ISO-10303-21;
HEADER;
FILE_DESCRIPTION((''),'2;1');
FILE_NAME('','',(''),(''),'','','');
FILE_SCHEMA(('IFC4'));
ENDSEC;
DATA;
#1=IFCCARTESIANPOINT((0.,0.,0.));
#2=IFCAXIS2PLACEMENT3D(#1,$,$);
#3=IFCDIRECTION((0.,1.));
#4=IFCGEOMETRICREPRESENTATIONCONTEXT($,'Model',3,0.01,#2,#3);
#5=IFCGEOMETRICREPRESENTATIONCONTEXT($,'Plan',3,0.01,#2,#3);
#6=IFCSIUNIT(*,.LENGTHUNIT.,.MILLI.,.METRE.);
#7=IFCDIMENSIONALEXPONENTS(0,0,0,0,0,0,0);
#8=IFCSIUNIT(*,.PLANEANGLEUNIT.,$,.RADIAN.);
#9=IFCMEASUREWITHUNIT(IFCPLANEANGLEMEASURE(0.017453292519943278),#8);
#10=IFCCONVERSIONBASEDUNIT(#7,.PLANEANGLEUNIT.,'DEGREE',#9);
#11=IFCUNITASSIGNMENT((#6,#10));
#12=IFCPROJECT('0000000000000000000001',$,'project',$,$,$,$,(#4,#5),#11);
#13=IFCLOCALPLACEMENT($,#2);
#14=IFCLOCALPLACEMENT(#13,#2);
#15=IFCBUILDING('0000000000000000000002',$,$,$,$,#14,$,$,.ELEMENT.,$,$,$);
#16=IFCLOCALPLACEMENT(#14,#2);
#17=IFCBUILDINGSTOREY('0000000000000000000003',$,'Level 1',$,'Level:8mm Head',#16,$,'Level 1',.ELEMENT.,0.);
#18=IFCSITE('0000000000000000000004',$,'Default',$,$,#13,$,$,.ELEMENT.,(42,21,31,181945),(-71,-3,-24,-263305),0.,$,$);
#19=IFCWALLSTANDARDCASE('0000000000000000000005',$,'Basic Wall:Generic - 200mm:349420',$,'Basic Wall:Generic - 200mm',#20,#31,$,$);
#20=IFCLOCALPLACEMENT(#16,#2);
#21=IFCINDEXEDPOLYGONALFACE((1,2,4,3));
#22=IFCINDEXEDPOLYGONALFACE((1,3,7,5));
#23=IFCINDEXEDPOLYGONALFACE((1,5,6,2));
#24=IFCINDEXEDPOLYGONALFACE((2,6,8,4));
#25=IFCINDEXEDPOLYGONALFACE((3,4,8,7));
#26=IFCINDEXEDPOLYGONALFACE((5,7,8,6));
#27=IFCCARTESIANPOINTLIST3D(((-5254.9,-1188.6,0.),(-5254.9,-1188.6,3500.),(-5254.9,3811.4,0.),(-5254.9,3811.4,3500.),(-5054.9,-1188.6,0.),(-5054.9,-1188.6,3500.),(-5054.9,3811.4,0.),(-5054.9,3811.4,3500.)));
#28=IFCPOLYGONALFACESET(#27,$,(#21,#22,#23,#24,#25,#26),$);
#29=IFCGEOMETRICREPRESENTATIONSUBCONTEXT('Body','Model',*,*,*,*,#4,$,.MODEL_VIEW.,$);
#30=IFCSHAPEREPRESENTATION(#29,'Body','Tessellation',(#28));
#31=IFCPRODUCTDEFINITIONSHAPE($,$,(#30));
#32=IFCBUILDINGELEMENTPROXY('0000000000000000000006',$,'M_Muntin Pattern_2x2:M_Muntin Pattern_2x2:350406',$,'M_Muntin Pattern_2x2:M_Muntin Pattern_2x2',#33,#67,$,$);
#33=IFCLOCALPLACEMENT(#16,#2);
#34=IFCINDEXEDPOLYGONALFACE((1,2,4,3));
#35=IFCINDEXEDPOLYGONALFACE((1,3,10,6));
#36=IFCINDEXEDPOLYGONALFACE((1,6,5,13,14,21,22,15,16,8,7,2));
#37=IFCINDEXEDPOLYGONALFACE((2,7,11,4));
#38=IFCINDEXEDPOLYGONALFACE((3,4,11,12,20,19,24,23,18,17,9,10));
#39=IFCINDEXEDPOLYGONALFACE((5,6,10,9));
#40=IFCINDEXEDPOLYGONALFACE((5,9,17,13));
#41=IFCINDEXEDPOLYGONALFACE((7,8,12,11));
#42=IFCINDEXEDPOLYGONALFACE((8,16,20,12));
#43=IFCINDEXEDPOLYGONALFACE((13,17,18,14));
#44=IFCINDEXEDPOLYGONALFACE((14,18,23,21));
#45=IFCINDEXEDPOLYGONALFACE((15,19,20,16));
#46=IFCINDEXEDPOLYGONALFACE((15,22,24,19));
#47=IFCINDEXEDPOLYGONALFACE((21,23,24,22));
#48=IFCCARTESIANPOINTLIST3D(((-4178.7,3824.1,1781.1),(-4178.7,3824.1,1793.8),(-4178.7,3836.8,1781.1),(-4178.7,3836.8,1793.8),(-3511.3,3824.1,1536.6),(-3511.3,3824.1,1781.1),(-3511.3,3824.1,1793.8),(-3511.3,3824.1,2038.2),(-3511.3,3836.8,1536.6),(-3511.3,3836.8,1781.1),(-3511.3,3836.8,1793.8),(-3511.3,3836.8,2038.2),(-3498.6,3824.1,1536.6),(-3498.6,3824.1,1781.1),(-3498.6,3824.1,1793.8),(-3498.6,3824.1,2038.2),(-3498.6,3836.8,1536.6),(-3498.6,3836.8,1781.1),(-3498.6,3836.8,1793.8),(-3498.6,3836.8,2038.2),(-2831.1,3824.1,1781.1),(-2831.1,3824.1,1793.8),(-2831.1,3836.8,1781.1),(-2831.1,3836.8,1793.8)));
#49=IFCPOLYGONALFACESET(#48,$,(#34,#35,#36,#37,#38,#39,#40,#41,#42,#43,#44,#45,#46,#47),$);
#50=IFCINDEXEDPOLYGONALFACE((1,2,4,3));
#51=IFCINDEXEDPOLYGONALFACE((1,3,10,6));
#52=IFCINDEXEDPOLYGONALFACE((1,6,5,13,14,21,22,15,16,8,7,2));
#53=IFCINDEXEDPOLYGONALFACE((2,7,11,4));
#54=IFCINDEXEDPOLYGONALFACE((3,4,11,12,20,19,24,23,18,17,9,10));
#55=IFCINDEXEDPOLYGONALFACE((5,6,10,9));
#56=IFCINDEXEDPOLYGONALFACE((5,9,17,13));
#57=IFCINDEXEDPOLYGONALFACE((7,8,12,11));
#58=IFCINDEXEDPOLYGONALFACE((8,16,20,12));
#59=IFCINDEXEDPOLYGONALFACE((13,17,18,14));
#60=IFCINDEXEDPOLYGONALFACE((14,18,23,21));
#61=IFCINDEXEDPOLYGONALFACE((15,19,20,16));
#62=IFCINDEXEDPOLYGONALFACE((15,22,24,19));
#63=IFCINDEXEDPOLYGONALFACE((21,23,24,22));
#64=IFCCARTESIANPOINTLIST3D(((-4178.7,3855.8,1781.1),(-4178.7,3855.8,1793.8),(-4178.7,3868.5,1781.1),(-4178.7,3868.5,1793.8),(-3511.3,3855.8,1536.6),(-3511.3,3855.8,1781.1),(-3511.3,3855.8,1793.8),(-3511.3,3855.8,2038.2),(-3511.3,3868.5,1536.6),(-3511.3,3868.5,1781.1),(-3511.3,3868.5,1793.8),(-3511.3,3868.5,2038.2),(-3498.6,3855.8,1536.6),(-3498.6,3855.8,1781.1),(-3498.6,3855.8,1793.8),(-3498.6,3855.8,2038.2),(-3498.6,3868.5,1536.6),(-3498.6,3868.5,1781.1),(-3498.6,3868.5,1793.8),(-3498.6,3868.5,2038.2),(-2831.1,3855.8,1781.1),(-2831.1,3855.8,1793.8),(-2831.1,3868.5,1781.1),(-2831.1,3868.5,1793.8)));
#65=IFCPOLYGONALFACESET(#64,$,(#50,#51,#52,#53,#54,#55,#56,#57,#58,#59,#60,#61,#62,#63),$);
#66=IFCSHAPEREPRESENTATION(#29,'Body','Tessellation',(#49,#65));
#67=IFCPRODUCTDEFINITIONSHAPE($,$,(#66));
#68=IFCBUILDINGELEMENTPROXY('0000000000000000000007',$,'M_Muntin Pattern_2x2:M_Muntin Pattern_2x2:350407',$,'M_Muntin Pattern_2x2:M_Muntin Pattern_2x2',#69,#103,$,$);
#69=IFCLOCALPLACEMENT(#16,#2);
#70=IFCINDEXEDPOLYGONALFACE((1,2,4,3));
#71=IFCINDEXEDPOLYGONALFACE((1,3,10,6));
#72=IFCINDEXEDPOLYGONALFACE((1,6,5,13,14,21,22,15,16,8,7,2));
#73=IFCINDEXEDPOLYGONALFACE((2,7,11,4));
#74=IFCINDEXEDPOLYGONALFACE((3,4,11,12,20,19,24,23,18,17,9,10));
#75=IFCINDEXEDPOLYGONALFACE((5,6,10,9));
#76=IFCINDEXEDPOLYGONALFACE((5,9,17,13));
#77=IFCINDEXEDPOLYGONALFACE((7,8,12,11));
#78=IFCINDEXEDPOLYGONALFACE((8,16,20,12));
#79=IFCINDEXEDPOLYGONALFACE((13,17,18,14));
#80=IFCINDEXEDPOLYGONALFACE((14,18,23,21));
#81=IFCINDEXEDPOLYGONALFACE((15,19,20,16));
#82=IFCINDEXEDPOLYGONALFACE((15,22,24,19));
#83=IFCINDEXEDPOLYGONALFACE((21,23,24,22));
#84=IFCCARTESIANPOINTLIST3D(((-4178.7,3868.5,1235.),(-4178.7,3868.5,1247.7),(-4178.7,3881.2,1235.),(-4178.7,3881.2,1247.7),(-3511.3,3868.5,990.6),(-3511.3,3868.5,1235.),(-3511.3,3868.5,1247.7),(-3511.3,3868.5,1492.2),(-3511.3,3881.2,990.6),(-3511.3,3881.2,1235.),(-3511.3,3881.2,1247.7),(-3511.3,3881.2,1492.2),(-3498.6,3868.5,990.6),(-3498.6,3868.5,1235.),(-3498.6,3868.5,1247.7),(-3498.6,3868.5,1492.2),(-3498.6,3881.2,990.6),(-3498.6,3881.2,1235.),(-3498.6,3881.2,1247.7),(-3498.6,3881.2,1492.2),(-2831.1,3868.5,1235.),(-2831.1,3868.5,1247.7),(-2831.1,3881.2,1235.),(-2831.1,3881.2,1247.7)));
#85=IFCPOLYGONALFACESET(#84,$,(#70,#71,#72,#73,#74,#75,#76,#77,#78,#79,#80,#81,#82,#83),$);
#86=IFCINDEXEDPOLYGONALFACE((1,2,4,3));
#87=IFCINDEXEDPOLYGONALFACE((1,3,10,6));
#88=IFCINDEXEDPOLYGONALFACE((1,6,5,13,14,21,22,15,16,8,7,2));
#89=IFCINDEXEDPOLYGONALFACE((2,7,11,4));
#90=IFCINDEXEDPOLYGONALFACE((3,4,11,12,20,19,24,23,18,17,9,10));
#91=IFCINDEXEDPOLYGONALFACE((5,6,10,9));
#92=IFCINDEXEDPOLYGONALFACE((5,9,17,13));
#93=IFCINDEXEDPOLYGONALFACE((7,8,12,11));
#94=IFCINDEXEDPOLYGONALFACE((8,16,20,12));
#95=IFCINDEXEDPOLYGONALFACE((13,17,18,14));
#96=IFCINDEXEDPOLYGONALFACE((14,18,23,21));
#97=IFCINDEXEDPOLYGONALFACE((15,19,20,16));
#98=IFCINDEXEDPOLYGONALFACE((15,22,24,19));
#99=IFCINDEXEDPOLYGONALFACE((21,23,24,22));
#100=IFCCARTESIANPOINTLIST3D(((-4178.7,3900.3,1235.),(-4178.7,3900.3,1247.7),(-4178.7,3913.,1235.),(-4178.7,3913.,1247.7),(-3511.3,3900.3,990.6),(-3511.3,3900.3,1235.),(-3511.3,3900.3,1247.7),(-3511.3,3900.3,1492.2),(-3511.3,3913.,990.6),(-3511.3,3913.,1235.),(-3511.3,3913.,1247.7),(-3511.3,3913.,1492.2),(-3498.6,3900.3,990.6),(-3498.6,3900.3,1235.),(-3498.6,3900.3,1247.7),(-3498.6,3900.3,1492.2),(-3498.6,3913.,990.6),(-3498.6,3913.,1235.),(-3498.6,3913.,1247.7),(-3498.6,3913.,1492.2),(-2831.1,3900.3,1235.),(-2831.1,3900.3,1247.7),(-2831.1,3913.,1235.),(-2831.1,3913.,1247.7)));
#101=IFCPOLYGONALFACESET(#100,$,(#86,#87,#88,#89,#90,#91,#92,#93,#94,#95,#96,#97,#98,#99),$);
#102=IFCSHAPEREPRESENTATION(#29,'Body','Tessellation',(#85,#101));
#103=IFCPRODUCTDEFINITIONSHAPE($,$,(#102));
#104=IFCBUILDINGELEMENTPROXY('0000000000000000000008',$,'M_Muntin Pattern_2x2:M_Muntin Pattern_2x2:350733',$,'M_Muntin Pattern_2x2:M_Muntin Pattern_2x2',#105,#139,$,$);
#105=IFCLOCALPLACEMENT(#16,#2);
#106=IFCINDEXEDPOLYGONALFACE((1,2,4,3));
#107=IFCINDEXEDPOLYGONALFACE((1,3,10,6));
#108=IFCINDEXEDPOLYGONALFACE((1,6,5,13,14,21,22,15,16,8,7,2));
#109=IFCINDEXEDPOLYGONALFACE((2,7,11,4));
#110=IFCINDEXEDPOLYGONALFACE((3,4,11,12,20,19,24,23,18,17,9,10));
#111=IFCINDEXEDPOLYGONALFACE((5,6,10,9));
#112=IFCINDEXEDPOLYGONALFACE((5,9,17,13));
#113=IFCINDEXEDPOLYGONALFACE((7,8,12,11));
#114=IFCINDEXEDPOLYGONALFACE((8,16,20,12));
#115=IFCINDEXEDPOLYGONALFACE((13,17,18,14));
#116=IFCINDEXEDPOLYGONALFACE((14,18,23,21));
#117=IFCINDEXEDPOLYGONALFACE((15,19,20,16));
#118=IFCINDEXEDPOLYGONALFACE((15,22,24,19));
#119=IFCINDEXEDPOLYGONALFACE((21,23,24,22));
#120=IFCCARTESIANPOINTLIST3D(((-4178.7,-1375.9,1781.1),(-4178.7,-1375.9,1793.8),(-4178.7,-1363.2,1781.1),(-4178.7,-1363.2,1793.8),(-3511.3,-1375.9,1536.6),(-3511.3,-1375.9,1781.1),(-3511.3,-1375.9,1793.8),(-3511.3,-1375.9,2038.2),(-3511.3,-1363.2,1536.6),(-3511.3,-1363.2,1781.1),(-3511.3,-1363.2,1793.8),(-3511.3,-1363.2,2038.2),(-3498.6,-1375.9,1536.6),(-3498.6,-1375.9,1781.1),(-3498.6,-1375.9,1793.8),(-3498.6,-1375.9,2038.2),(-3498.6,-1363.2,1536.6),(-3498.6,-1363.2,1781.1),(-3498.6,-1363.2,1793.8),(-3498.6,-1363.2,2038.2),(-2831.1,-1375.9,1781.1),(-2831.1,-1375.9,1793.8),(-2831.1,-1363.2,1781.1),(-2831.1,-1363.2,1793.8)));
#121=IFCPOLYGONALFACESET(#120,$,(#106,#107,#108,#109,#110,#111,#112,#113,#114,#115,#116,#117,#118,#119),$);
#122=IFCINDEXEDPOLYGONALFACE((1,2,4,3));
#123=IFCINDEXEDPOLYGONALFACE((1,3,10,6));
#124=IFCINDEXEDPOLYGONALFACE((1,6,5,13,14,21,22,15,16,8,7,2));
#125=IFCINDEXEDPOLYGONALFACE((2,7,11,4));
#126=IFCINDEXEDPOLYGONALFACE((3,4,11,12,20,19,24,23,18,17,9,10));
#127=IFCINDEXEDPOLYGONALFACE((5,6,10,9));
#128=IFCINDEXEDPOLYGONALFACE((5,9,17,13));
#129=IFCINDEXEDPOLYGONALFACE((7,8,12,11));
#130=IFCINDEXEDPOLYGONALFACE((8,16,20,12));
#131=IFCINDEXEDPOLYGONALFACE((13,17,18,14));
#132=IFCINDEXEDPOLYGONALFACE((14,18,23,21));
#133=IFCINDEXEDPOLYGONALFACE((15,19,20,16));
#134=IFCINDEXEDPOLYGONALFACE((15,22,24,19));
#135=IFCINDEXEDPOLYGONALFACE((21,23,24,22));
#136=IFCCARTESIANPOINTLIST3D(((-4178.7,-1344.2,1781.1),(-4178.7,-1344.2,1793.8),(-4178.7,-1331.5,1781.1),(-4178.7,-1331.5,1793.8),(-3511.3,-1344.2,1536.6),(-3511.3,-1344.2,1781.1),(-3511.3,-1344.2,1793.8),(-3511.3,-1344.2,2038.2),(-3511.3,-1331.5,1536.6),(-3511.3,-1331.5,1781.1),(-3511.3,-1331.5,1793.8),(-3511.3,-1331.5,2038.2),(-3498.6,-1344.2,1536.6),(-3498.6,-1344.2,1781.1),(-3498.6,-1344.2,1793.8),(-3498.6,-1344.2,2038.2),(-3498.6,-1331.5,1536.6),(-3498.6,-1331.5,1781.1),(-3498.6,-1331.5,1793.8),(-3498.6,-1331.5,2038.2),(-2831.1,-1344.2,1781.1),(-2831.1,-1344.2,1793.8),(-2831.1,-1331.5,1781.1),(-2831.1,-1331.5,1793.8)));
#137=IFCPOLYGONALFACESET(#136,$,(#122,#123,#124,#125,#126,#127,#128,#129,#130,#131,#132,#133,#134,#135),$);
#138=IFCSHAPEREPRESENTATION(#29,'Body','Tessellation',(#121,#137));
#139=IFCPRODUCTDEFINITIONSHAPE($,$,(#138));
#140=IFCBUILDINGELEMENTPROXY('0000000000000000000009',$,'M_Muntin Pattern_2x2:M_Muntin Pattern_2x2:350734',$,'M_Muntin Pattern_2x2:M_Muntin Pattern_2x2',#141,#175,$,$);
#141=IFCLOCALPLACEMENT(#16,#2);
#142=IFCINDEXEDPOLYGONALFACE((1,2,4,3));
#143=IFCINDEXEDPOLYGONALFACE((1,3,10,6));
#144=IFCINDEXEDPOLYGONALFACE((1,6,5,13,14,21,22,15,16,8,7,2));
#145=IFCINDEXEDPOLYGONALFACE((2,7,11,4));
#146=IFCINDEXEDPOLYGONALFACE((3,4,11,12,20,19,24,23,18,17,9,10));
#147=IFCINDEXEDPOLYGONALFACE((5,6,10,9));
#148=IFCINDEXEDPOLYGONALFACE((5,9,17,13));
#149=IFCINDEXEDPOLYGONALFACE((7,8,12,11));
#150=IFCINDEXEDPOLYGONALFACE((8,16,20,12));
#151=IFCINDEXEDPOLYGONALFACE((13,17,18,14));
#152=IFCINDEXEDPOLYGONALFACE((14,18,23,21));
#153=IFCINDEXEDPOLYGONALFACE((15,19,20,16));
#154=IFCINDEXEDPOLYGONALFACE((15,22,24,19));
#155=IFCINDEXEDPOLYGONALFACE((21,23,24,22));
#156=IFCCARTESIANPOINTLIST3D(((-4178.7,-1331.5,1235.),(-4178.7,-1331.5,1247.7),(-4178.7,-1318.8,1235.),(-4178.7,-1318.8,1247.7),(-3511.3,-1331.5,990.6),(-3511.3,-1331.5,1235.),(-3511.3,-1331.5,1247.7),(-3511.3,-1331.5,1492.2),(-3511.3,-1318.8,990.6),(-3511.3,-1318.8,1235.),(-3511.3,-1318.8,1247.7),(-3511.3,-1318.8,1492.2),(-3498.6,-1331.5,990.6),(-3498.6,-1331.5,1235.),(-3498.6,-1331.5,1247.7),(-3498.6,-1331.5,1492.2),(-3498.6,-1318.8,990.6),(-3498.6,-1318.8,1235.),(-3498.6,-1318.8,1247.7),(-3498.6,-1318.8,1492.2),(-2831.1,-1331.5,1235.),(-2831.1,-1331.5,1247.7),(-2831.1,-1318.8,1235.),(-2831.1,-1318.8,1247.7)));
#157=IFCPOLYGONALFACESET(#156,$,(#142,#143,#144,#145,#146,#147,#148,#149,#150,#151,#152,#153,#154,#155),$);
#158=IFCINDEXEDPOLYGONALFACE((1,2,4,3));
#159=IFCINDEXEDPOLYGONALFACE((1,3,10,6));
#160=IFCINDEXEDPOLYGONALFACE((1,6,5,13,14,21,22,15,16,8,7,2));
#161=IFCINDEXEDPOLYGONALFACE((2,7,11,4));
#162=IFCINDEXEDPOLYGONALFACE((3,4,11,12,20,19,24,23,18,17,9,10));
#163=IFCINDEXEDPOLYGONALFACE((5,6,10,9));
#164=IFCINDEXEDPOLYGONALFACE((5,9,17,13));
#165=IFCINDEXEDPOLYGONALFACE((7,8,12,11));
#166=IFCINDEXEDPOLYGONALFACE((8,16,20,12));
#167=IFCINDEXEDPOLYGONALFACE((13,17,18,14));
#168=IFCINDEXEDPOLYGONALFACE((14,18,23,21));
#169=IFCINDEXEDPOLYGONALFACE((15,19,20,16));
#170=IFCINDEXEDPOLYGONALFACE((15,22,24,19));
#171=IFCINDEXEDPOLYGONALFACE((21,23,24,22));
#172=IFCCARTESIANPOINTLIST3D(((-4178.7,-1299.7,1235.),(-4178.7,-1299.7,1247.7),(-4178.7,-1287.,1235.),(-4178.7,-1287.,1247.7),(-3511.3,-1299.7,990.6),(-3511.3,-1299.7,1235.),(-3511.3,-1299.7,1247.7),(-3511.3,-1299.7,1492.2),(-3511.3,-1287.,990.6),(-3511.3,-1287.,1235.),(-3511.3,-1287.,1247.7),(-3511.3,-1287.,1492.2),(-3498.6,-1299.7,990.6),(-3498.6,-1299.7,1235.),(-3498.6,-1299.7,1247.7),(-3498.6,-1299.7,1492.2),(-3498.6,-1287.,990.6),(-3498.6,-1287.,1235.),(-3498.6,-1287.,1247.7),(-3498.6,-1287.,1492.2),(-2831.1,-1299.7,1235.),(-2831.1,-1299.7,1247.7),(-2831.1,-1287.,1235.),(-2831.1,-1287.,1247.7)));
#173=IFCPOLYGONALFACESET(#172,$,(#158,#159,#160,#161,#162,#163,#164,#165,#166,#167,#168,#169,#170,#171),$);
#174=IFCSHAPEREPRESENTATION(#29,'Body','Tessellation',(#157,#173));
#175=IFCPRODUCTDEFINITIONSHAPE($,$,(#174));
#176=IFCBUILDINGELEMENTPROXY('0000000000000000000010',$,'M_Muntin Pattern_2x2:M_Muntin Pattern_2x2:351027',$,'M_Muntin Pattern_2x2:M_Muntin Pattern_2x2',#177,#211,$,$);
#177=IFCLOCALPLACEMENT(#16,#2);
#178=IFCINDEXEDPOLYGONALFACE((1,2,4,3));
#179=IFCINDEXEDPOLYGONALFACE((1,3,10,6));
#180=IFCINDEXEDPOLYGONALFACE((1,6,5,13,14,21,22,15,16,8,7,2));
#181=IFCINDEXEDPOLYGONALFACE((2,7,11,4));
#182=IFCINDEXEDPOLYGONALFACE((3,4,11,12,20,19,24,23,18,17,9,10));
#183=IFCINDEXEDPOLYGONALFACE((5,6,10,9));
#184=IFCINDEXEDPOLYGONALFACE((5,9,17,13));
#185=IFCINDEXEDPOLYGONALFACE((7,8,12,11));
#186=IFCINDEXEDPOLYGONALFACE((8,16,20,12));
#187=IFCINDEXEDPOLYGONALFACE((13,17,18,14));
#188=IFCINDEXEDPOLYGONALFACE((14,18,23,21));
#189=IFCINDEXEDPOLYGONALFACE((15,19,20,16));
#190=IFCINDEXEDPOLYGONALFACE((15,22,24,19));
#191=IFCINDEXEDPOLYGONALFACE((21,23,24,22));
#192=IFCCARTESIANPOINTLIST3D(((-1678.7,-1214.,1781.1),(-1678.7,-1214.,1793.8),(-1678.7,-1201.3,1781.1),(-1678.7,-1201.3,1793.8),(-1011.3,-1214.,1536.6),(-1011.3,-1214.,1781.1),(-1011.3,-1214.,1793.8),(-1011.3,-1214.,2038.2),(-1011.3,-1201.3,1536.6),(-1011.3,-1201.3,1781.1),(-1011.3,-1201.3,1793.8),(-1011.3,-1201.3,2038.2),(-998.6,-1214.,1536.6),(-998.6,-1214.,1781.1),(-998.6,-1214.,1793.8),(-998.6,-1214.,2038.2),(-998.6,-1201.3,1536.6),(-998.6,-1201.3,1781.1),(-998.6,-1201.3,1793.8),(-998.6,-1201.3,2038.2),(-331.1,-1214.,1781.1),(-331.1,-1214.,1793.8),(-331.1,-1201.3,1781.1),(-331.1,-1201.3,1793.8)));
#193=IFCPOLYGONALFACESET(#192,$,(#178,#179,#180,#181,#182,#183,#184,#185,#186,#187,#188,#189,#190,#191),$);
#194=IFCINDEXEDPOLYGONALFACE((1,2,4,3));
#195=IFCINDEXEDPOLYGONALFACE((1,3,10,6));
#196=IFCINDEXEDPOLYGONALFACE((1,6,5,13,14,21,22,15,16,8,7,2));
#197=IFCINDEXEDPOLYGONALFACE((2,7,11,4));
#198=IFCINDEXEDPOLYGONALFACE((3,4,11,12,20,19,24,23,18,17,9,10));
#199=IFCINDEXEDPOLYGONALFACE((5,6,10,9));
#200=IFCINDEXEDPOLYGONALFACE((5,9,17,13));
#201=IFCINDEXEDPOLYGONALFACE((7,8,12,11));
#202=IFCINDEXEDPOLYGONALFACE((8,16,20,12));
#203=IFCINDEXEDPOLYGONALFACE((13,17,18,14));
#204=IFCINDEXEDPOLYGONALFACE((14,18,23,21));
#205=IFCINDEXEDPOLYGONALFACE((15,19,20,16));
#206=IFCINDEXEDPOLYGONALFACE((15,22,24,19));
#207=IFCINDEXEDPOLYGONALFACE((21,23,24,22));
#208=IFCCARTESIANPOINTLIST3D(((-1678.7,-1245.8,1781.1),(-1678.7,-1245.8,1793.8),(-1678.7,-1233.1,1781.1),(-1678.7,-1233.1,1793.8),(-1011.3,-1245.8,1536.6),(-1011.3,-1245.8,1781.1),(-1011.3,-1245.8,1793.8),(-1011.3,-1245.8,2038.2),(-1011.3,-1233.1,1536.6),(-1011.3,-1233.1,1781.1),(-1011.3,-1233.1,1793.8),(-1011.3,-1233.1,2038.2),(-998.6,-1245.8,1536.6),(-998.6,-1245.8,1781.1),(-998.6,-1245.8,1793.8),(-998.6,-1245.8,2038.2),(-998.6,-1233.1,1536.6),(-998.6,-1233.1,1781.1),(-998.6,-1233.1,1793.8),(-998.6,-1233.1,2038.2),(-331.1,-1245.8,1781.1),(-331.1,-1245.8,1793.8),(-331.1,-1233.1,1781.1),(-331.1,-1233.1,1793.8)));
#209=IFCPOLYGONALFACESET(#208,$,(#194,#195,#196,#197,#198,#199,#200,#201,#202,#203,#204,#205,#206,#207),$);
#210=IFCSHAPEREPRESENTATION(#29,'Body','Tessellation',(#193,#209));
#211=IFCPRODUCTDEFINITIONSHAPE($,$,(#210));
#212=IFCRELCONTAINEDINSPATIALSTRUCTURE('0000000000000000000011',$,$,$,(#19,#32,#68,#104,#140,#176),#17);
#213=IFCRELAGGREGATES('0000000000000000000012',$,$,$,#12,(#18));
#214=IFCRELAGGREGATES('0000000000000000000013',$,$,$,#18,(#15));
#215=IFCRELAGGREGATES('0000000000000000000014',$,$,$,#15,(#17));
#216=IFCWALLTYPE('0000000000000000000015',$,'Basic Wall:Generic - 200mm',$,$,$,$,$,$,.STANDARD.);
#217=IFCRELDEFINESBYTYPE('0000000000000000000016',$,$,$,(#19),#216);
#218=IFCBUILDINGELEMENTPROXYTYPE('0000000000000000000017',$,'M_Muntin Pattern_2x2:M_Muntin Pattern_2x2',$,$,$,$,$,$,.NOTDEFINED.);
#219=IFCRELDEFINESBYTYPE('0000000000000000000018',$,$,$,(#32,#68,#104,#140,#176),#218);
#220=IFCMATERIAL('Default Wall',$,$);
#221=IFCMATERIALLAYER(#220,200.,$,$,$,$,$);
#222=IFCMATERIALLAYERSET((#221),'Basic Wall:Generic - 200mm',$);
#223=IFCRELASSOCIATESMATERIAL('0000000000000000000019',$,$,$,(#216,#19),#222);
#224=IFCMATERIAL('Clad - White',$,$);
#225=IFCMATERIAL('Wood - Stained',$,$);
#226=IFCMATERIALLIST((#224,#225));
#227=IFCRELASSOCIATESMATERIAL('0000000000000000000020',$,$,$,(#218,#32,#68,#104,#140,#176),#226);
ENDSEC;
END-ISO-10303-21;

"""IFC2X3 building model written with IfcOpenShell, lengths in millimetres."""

from ifc_helpers import new_model, entity, si_unit, converted_unit, direction, frame, frame_2d, origin, place, context, subcontext, project, spatial, polyline, rectangle, outline, extrude, source, transform, mapped, material, material_list, layer, layer_set, layer_usage, type_object, type_shapes, element, save


model = new_model("IFC2X3")

# Units and contexts
model_context = context("Model", 3, precision=0.01, world=origin(), true_north=direction((0.0, 1.0)))
plan_context = context("Plan", 3, precision=0.01, world=origin(), true_north=direction((0.0, 1.0)))
body_context = subcontext(model_context, "Body", "Model", "MODEL_VIEW")
ifc_project = project(units=[si_unit("LENGTHUNIT", "METRE", prefix="MILLI"), converted_unit("PLANEANGLEUNIT", "DEGREE", entity("IfcPlaneAngleMeasure", 0.017453292519943278), si_unit("PLANEANGLEUNIT", "RADIAN"), dimensions=[0, 0, 0, 0, 0, 0, 0])], contexts=[model_context, plan_context])

# Site, building, storey
site_placement = place(None, origin())
site = spatial("IfcSite", under=ifc_project, at=site_placement, Name="Default", CompositionType="ELEMENT", RefLatitude=(42, 21, 31, 181945), RefLongitude=(-71, -3, -24, -263305), RefElevation=0.0)
building_placement = place(site_placement, origin())
building = spatial("IfcBuilding", under=site, at=building_placement, CompositionType="ELEMENT")
storey_placement = place(building_placement, origin())
storey = spatial("IfcBuildingStorey", under=building, at=storey_placement, Name="Level 1", ObjectType="Level:8mm Head", LongName="Level 1", CompositionType="ELEMENT", Elevation=0.0)

# Shared definitions
ifc_material_1 = material(Name="Default Wall")
ifc_layer = layer(ifc_material_1, 200.0)
ifc_layer_set = layer_set([ifc_layer], Name="Basic Wall:Generic - 200mm")
wall_type = type_object("IfcWallType", Name="Basic Wall:Generic - 200mm", PredefinedType="STANDARD", material=ifc_layer_set)
ifc_material_2 = material(Name="Wood - Stained")

# Wall
ifc_layer_usage_1 = layer_usage(ifc_layer_set, "AXIS2", "NEGATIVE", 100.0)
wall_1_placement = place(storey_placement, frame((-5154.9, -1188.6, 0.0), z_axis=(0.0, 0.0, 1.0), x_axis=(0.0, 1.0, 0.0)))
element("IfcWallStandardCase", 1, at=wall_1_placement, inside=storey, type_object=wall_type, material=ifc_layer_usage_1, Name="Basic Wall:Generic - 200mm:349420", ObjectType="Basic Wall:Generic - 200mm", context=body_context, shape_type="SweptSolid", body=[
    extrude(rectangle(XDim=5000.0, YDim=200.0, at=frame_2d((2500.0, 0.0), x_axis=(-1.0, 0.0))), origin(), (0.0, 0.0, 1.0), 3500.0),
])

# Building element proxies
ifc_material_3 = material(Name="Clad - White")
ifc_material_list_1 = material_list([ifc_material_3, ifc_material_2])
building_element_proxy_type_1 = type_object("IfcBuildingElementProxyType", Name="M_Muntin Pattern_2x2:M_Muntin Pattern_2x2", PredefinedType="NOTDEFINED", material=ifc_material_list_1)
shared_shape_1 = source(origin(), body_context, "Body", "SweptSolid", [
    extrude(outline(polyline([(6.4, -6.4), (250.8, -6.4), (250.8, 6.3), (6.4, 6.3), (6.4, 673.8), (-6.3, 673.8), (-6.3, 6.3), (-250.8, 6.3), (-250.8, -6.4), (-6.3, -6.4), (-6.3, -673.8), (6.4, -673.8), (6.4, -6.4)])), frame((0.0, 9.5, 250.8), z_axis=(0.0, 1.0, 0.0), x_axis=(0.0, 0.0, 1.0)), (0.0, 0.0, 1.0), 12.7),
    extrude(outline(polyline([(6.4, -6.4), (250.8, -6.4), (250.8, 6.3), (6.4, 6.3), (6.4, 673.8), (-6.3, 673.8), (-6.3, 6.3), (-250.8, 6.3), (-250.8, -6.4), (-6.3, -6.4), (-6.3, -673.8), (6.4, -673.8), (6.4, -6.4)])), frame((0.0, -22.2, 250.8), z_axis=(0.0, 1.0, 0.0), x_axis=(0.0, 0.0, 1.0)), (0.0, 0.0, 1.0), 12.7),
])
type_shapes(building_element_proxy_type_1, [shared_shape_1])
for number, where, z_axis, x_axis, name in (
    (2, (-3504.9, 3846.3, 1536.6), (0.0, 0.0, 1.0), (-1.0, 0.0, 0.0), "M_Muntin Pattern_2x2:M_Muntin Pattern_2x2:350406"),
    (3, (-3504.9, 3890.7, 990.6), (0.0, 0.0, 1.0), (-1.0, 0.0, 0.0), "M_Muntin Pattern_2x2:M_Muntin Pattern_2x2:350407"),
    (4, (-3504.9, -1353.7, 1536.6), (0.0, 0.0, 1.0), (-1.0, 0.0, 0.0), "M_Muntin Pattern_2x2:M_Muntin Pattern_2x2:350733"),
    (5, (-3504.9, -1309.3, 990.6), (0.0, 0.0, 1.0), (-1.0, 0.0, 0.0), "M_Muntin Pattern_2x2:M_Muntin Pattern_2x2:350734"),
):
    element("IfcBuildingElementProxy", number, at=place(storey_placement, frame(where, z_axis=z_axis, x_axis=x_axis)), inside=storey, type_object=building_element_proxy_type_1, material=ifc_material_list_1, Name=name, ObjectType="M_Muntin Pattern_2x2:M_Muntin Pattern_2x2", context=body_context, shape_type="MappedRepresentation", body=[
        mapped(shared_shape_1, transform((0.0, 0.0, 0.0), scale=1.0)),
    ])
for number, where, name in (
    (6, (-1004.9, -1223.6, 1536.6), "M_Muntin Pattern_2x2:M_Muntin Pattern_2x2:351027"),
):
    element("IfcBuildingElementProxy", number, at=place(storey_placement, frame(where)), inside=storey, type_object=building_element_proxy_type_1, material=ifc_material_list_1, Name=name, ObjectType="M_Muntin Pattern_2x2:M_Muntin Pattern_2x2", context=body_context, shape_type="MappedRepresentation", body=[
        mapped(shared_shape_1, transform((0.0, 0.0, 0.0), scale=1.0)),
    ])

save(model, "model.ifc")
